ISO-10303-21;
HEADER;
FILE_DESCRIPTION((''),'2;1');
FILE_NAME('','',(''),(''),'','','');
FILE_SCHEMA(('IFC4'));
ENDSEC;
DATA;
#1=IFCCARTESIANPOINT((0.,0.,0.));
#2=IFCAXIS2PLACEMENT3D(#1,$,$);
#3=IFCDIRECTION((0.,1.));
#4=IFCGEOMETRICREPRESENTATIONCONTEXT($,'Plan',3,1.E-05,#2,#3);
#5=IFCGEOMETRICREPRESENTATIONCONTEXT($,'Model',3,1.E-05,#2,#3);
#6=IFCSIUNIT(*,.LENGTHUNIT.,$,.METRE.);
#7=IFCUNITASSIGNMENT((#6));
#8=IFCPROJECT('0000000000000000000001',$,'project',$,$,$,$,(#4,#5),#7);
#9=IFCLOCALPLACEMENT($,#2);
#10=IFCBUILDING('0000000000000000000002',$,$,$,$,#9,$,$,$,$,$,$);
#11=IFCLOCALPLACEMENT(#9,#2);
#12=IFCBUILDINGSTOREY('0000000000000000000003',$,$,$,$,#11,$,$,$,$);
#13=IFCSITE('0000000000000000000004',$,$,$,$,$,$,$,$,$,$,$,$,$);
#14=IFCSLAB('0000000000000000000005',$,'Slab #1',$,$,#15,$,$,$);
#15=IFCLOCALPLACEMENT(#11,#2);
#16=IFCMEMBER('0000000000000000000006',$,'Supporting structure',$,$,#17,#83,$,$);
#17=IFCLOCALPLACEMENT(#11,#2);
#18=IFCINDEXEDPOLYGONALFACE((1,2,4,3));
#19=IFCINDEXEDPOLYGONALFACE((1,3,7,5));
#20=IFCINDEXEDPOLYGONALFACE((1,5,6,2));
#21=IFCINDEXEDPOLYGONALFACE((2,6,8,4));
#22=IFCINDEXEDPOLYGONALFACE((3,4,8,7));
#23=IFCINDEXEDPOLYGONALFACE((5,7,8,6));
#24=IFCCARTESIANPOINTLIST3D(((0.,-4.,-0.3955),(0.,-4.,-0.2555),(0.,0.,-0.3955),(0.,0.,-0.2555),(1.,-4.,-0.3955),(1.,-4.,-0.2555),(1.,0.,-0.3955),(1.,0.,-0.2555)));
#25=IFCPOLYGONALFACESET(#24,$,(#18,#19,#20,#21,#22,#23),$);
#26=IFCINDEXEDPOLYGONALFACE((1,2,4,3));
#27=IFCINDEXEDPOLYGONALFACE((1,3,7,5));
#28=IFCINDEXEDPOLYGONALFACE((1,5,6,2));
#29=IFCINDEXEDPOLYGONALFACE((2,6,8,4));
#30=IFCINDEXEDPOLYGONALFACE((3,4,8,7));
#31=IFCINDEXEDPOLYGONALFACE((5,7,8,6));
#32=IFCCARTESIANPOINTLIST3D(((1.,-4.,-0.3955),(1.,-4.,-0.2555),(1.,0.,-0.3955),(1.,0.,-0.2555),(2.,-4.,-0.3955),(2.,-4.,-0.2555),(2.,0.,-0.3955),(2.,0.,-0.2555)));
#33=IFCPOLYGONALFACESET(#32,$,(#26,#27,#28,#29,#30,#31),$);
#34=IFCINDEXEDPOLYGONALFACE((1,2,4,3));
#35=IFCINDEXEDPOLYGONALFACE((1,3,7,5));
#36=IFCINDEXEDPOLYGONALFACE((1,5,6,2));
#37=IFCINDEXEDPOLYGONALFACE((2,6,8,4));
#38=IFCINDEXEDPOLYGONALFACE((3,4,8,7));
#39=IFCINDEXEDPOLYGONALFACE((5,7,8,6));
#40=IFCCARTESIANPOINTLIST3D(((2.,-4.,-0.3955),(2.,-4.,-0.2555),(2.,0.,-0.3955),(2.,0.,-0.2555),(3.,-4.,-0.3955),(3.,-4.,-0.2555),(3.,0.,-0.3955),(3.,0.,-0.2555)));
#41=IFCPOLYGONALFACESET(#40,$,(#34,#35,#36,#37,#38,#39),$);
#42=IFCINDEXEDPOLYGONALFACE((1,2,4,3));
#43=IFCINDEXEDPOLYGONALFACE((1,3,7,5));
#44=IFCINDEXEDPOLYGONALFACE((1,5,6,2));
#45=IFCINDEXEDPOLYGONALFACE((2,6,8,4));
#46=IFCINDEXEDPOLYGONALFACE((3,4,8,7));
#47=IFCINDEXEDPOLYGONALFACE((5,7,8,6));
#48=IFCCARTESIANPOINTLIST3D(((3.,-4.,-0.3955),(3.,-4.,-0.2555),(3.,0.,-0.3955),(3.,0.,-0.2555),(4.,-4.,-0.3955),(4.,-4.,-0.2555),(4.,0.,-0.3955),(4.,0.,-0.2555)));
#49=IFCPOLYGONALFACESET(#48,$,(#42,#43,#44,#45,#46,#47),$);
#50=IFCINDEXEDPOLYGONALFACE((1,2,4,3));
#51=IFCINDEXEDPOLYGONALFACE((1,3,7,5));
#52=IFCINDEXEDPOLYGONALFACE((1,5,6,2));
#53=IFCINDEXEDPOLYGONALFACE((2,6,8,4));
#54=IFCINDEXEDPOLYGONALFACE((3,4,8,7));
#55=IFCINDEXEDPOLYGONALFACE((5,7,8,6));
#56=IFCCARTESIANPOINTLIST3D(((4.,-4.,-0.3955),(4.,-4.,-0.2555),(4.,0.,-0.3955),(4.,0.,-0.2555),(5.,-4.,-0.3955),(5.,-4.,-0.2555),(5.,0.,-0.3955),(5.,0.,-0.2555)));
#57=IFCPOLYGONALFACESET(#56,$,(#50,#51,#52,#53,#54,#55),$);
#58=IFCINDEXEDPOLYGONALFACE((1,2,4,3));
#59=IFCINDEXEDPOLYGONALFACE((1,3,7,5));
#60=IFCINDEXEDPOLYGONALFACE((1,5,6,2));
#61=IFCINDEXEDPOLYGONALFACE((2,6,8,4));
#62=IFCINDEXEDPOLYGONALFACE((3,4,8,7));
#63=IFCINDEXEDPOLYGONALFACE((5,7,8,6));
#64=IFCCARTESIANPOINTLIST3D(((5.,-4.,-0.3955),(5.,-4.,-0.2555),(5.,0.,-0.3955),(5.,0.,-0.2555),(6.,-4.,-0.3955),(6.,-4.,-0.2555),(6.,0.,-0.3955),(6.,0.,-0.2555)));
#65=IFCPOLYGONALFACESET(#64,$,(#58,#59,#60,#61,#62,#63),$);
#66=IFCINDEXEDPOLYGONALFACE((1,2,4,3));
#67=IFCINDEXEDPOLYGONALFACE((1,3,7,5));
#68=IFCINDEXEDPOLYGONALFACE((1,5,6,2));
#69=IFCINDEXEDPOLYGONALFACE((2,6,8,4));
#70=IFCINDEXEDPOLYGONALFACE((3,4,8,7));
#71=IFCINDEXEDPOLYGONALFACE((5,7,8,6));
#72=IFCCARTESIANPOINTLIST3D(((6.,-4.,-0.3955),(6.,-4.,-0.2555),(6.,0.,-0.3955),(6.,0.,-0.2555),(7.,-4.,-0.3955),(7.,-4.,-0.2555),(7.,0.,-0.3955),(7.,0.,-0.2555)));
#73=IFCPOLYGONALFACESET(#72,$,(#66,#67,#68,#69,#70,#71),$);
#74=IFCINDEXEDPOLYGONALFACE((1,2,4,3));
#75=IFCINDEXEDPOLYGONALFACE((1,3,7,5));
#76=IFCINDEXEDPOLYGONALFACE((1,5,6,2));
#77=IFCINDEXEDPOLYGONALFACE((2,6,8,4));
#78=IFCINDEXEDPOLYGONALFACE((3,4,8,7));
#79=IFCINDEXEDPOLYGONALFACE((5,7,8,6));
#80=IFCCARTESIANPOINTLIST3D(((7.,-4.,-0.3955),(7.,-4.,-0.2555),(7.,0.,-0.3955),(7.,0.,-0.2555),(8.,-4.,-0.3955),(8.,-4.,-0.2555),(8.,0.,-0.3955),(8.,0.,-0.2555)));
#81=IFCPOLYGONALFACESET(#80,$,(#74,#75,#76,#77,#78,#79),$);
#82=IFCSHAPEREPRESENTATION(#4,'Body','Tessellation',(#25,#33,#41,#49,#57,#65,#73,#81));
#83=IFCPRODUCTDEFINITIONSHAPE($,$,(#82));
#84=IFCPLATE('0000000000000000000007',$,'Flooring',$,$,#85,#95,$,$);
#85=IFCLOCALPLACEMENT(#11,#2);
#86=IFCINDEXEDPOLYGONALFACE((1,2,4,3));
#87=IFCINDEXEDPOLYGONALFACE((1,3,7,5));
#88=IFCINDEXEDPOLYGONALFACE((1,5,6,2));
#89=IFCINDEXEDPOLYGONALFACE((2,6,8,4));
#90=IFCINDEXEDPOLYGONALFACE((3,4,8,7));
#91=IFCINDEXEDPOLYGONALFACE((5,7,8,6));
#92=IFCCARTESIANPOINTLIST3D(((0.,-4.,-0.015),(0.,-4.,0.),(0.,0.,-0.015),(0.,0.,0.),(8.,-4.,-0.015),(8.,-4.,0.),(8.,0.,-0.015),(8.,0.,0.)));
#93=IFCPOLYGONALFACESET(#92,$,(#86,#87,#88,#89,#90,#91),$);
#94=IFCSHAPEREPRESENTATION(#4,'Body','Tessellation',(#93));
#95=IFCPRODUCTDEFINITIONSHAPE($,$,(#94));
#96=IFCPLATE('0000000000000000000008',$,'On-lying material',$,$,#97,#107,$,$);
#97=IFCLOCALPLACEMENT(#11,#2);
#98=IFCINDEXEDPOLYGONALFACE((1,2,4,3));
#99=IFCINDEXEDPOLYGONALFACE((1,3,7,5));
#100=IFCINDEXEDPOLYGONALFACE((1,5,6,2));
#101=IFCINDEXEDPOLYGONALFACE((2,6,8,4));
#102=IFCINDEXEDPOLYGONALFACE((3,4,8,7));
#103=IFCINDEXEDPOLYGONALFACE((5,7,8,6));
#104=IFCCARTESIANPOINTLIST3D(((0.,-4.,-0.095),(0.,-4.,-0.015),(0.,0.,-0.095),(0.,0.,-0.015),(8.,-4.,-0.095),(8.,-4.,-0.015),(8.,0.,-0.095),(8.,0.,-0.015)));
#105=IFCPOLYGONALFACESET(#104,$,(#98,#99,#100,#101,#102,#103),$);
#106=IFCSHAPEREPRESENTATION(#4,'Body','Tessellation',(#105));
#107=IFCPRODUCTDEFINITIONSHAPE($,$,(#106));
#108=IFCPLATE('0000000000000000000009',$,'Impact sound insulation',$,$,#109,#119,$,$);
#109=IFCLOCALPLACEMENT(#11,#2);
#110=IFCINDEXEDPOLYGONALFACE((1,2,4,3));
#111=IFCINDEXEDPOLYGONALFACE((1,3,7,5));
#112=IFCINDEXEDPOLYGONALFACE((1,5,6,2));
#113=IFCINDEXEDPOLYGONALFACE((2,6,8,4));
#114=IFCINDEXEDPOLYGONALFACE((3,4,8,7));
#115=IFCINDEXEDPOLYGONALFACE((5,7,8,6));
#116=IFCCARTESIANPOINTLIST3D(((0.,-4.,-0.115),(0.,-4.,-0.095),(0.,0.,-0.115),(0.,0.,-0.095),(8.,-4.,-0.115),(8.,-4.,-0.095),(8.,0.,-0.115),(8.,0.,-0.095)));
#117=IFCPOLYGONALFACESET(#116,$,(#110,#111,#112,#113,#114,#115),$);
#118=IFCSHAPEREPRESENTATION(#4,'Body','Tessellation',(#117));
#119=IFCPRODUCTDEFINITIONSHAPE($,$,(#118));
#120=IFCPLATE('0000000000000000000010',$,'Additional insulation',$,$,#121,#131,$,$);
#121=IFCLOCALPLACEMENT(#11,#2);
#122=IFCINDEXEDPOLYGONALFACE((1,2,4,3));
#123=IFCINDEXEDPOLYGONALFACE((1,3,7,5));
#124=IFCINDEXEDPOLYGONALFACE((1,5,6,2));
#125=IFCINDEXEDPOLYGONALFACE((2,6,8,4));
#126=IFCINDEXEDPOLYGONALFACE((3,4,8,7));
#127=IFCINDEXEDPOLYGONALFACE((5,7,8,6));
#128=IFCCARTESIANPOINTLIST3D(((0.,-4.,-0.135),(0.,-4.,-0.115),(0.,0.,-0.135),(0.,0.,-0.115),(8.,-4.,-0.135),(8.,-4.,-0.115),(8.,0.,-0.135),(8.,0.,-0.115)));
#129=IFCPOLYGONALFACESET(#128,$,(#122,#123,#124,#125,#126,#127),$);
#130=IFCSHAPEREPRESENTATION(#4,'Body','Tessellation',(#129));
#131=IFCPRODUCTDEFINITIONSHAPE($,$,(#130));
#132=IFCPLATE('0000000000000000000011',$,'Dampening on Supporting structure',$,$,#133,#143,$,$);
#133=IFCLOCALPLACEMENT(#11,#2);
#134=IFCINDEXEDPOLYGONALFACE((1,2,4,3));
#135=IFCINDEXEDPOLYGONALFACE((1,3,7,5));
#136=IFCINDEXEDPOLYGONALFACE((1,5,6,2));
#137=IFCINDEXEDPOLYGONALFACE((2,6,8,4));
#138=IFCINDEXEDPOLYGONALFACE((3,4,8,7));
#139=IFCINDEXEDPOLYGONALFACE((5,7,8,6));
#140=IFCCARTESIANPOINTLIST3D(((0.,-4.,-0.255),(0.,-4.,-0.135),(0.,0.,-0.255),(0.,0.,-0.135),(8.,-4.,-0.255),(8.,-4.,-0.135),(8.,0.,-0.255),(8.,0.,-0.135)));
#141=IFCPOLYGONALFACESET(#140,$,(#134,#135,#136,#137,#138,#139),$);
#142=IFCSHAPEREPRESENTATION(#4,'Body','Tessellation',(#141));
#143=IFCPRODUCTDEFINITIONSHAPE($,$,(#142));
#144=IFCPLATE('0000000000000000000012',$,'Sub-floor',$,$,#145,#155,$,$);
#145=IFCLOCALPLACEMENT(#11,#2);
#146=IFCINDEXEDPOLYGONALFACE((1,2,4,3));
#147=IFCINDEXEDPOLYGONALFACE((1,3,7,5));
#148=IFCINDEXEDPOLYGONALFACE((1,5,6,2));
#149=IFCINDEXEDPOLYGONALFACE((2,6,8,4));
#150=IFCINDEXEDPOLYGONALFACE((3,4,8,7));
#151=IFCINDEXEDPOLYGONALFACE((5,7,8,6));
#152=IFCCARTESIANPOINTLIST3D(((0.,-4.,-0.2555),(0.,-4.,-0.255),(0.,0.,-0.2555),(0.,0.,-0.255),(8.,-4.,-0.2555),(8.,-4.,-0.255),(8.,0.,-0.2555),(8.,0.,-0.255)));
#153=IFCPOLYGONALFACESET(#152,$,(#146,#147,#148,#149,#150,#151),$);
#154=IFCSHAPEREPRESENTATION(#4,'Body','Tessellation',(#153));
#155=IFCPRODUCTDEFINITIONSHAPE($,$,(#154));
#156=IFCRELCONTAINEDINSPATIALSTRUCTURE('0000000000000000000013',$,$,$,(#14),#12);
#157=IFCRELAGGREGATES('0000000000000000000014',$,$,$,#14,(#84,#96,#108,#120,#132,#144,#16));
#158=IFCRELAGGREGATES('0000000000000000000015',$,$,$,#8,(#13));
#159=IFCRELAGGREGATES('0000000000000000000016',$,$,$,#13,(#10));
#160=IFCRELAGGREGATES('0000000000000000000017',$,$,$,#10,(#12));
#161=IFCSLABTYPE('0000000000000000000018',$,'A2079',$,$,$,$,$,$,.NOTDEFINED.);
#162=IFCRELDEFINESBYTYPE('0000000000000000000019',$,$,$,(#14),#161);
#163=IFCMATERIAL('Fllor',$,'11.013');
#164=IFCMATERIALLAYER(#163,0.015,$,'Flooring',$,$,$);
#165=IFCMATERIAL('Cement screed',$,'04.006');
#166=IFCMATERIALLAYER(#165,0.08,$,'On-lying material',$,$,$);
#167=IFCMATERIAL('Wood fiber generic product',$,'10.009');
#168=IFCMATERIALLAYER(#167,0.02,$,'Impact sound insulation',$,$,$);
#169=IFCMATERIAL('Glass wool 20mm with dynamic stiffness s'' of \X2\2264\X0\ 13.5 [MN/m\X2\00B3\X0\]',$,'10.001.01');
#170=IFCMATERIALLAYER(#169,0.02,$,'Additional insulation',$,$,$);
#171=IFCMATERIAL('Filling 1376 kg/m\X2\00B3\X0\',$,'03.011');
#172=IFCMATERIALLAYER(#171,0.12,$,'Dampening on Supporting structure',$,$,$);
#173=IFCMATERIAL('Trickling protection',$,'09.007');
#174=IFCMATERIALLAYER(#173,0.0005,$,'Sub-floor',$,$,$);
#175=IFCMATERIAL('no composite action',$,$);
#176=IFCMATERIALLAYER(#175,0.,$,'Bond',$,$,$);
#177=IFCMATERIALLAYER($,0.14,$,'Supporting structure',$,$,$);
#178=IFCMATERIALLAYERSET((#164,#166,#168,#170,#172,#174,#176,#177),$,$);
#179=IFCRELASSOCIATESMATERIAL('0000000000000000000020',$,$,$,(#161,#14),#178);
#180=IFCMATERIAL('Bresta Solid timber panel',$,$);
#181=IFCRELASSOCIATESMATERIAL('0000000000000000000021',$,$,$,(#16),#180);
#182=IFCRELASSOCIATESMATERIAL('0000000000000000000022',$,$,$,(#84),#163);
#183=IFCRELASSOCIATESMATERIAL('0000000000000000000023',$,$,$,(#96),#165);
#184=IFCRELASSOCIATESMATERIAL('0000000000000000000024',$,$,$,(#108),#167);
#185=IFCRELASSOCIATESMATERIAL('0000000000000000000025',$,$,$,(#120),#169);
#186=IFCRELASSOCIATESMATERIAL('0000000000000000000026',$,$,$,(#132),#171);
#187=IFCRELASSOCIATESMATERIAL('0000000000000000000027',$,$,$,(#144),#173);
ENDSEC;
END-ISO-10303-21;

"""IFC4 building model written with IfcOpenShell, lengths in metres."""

from ifc_helpers import new_model, si_unit, direction, frame, frame_2d, origin, origin_with_axes, place, context, project, spatial, rectangle, extrude, material, layer, layer_set, type_object, element, aggregate, save


model = new_model("IFC4")

# Units and contexts
plan_context = context("Plan", 3, precision=1e-05, world=origin(), true_north=direction((0.0, 1.0)))
model_context = context("Model", 3, precision=1e-05, world=origin(), true_north=direction((0.0, 1.0)))
ifc_project = project(units=[si_unit("LENGTHUNIT", "METRE")], contexts=[plan_context, model_context])

# Site, building, storey
site = spatial("IfcSite", under=ifc_project)
building_placement = place(None, origin())
building = spatial("IfcBuilding", under=site, at=building_placement)
storey_placement = place(building_placement, origin())
storey = spatial("IfcBuildingStorey", under=building, at=storey_placement)

# Slab, member, plates
ifc_material_1 = material(Name="Fllor", Category="11.013")
ifc_layer_1 = layer(ifc_material_1, 0.015, Name="Flooring")
ifc_material_2 = material(Name="Cement screed", Category="04.006")
ifc_layer_2 = layer(ifc_material_2, 0.08, Name="On-lying material")
ifc_material_3 = material(Name="Wood fiber generic product", Category="10.009")
ifc_layer_3 = layer(ifc_material_3, 0.02, Name="Impact sound insulation")
ifc_material_4 = material(Name="Glass wool 20mm with dynamic stiffness s' of ≤ 13.5 [MN/m³]", Category="10.001.01")
ifc_layer_4 = layer(ifc_material_4, 0.02, Name="Additional insulation")
ifc_material_5 = material(Name="Filling 1376 kg/m³", Category="03.011")
ifc_layer_5 = layer(ifc_material_5, 0.12, Name="Dampening on Supporting structure")
ifc_material_6 = material(Name="Trickling protection", Category="09.007")
ifc_layer_6 = layer(ifc_material_6, 0.0005, Name="Sub-floor")
ifc_material_7 = material(Name="no composite action")
ifc_layer_7 = layer(ifc_material_7, 0.0, Name="Bond")
ifc_layer_8 = layer(None, 0.14, Name="Supporting structure")
ifc_layer_set = layer_set([ifc_layer_1, ifc_layer_2, ifc_layer_3, ifc_layer_4, ifc_layer_5, ifc_layer_6, ifc_layer_7, ifc_layer_8])
slab_type = type_object("IfcSlabType", Name="A2079", PredefinedType="NOTDEFINED", material=ifc_layer_set)
slab_placement = place(None, frame((0.0, 0.0, 0.0), z_axis=(0.0, 0.0, -1.0), x_axis=(1.0, 0.0, 0.0)))
slab = element("IfcSlab", 1, at=slab_placement, inside=storey, type_object=slab_type, material=ifc_layer_set, Name="Slab #1")
ifc_material_8 = material(Name="Bresta Solid timber panel")
member_placement = place(slab_placement, origin())
member = element("IfcMember", 2, at=member_placement, material=ifc_material_8, Name="Supporting structure", context=plan_context, shape_type="SweptSolid", body=[
    extrude(rectangle(XDim=1.0, YDim=0.14, at=frame_2d((0.5, 0.07), x_axis=(1.0, 0.0))), frame((0.0, 4.0, 0.2555), z_axis=(0.0, -1.0, 0.0), x_axis=(1.0, 0.0, 0.0)), (0.0, 0.0, 1.0), 4.0),
    extrude(rectangle(XDim=1.0, YDim=0.14, at=frame_2d((0.5, 0.07), x_axis=(1.0, 0.0))), frame((1.0, 4.0, 0.2555), z_axis=(0.0, -1.0, 0.0), x_axis=(1.0, 0.0, 0.0)), (0.0, 0.0, 1.0), 4.0),
    extrude(rectangle(XDim=1.0, YDim=0.14, at=frame_2d((0.5, 0.07), x_axis=(1.0, 0.0))), frame((2.0, 4.0, 0.2555), z_axis=(0.0, -1.0, 0.0), x_axis=(1.0, 0.0, 0.0)), (0.0, 0.0, 1.0), 4.0),
    extrude(rectangle(XDim=1.0, YDim=0.14, at=frame_2d((0.5, 0.07), x_axis=(1.0, 0.0))), frame((3.0, 4.0, 0.2555), z_axis=(0.0, -1.0, 0.0), x_axis=(1.0, 0.0, 0.0)), (0.0, 0.0, 1.0), 4.0),
    extrude(rectangle(XDim=1.0, YDim=0.14, at=frame_2d((0.5, 0.07), x_axis=(1.0, 0.0))), frame((4.0, 4.0, 0.2555), z_axis=(0.0, -1.0, 0.0), x_axis=(1.0, 0.0, 0.0)), (0.0, 0.0, 1.0), 4.0),
    extrude(rectangle(XDim=1.0, YDim=0.14, at=frame_2d((0.5, 0.07), x_axis=(1.0, 0.0))), frame((5.0, 4.0, 0.2555), z_axis=(0.0, -1.0, 0.0), x_axis=(1.0, 0.0, 0.0)), (0.0, 0.0, 1.0), 4.0),
    extrude(rectangle(XDim=1.0, YDim=0.14, at=frame_2d((0.5, 0.07), x_axis=(1.0, 0.0))), frame((6.0, 4.0, 0.2555), z_axis=(0.0, -1.0, 0.0), x_axis=(1.0, 0.0, 0.0)), (0.0, 0.0, 1.0), 4.0),
    extrude(rectangle(XDim=1.0, YDim=0.14, at=frame_2d((0.5, 0.07), x_axis=(1.0, 0.0))), frame((7.0, 4.0, 0.2555), z_axis=(0.0, -1.0, 0.0), x_axis=(1.0, 0.0, 0.0)), (0.0, 0.0, 1.0), 4.0),
])
plate_1_placement = place(slab_placement, origin())
plate_1 = element("IfcPlate", 3, at=plate_1_placement, material=ifc_material_1, Name="Flooring", context=plan_context, shape_type="SweptSolid", body=[
    extrude(rectangle(XDim=8.0, YDim=4.0, at=frame_2d((4.0, 2.0), x_axis=(1.0, 0.0))), origin_with_axes(), (0.0, 0.0, 1.0), 0.015),
])
plate_2_placement = place(slab_placement, origin())
plate_2 = element("IfcPlate", 4, at=plate_2_placement, material=ifc_material_2, Name="On-lying material", context=plan_context, shape_type="SweptSolid", body=[
    extrude(rectangle(XDim=8.0, YDim=4.0, at=frame_2d((4.0, 2.0), x_axis=(1.0, 0.0))), frame((0.0, 0.0, 0.015), z_axis=(0.0, 0.0, 1.0), x_axis=(1.0, 0.0, 0.0)), (0.0, 0.0, 1.0), 0.08),
])
plate_3_placement = place(slab_placement, origin())
plate_3 = element("IfcPlate", 5, at=plate_3_placement, material=ifc_material_3, Name="Impact sound insulation", context=plan_context, shape_type="SweptSolid", body=[
    extrude(rectangle(XDim=8.0, YDim=4.0, at=frame_2d((4.0, 2.0), x_axis=(1.0, 0.0))), frame((0.0, 0.0, 0.095), z_axis=(0.0, 0.0, 1.0), x_axis=(1.0, 0.0, 0.0)), (0.0, 0.0, 1.0), 0.02),
])
plate_4_placement = place(slab_placement, origin())
plate_4 = element("IfcPlate", 6, at=plate_4_placement, material=ifc_material_4, Name="Additional insulation", context=plan_context, shape_type="SweptSolid", body=[
    extrude(rectangle(XDim=8.0, YDim=4.0, at=frame_2d((4.0, 2.0), x_axis=(1.0, 0.0))), frame((0.0, 0.0, 0.115), z_axis=(0.0, 0.0, 1.0), x_axis=(1.0, 0.0, 0.0)), (0.0, 0.0, 1.0), 0.02),
])
plate_5_placement = place(slab_placement, origin())
plate_5 = element("IfcPlate", 7, at=plate_5_placement, material=ifc_material_5, Name="Dampening on Supporting structure", context=plan_context, shape_type="SweptSolid", body=[
    extrude(rectangle(XDim=8.0, YDim=4.0, at=frame_2d((4.0, 2.0), x_axis=(1.0, 0.0))), frame((0.0, 0.0, 0.135), z_axis=(0.0, 0.0, 1.0), x_axis=(1.0, 0.0, 0.0)), (0.0, 0.0, 1.0), 0.12),
])
plate_6_placement = place(slab_placement, origin())
plate_6 = element("IfcPlate", 8, at=plate_6_placement, material=ifc_material_6, Name="Sub-floor", context=plan_context, shape_type="SweptSolid", body=[
    extrude(rectangle(XDim=8.0, YDim=4.0, at=frame_2d((4.0, 2.0), x_axis=(1.0, 0.0))), frame((0.0, 0.0, 0.255), z_axis=(0.0, 0.0, 1.0), x_axis=(1.0, 0.0, 0.0)), (0.0, 0.0, 1.0), 0.0005),
])
aggregate(slab, [plate_1, plate_2, plate_3, plate_4, plate_5, plate_6, member])

save(model, "model.ifc")
